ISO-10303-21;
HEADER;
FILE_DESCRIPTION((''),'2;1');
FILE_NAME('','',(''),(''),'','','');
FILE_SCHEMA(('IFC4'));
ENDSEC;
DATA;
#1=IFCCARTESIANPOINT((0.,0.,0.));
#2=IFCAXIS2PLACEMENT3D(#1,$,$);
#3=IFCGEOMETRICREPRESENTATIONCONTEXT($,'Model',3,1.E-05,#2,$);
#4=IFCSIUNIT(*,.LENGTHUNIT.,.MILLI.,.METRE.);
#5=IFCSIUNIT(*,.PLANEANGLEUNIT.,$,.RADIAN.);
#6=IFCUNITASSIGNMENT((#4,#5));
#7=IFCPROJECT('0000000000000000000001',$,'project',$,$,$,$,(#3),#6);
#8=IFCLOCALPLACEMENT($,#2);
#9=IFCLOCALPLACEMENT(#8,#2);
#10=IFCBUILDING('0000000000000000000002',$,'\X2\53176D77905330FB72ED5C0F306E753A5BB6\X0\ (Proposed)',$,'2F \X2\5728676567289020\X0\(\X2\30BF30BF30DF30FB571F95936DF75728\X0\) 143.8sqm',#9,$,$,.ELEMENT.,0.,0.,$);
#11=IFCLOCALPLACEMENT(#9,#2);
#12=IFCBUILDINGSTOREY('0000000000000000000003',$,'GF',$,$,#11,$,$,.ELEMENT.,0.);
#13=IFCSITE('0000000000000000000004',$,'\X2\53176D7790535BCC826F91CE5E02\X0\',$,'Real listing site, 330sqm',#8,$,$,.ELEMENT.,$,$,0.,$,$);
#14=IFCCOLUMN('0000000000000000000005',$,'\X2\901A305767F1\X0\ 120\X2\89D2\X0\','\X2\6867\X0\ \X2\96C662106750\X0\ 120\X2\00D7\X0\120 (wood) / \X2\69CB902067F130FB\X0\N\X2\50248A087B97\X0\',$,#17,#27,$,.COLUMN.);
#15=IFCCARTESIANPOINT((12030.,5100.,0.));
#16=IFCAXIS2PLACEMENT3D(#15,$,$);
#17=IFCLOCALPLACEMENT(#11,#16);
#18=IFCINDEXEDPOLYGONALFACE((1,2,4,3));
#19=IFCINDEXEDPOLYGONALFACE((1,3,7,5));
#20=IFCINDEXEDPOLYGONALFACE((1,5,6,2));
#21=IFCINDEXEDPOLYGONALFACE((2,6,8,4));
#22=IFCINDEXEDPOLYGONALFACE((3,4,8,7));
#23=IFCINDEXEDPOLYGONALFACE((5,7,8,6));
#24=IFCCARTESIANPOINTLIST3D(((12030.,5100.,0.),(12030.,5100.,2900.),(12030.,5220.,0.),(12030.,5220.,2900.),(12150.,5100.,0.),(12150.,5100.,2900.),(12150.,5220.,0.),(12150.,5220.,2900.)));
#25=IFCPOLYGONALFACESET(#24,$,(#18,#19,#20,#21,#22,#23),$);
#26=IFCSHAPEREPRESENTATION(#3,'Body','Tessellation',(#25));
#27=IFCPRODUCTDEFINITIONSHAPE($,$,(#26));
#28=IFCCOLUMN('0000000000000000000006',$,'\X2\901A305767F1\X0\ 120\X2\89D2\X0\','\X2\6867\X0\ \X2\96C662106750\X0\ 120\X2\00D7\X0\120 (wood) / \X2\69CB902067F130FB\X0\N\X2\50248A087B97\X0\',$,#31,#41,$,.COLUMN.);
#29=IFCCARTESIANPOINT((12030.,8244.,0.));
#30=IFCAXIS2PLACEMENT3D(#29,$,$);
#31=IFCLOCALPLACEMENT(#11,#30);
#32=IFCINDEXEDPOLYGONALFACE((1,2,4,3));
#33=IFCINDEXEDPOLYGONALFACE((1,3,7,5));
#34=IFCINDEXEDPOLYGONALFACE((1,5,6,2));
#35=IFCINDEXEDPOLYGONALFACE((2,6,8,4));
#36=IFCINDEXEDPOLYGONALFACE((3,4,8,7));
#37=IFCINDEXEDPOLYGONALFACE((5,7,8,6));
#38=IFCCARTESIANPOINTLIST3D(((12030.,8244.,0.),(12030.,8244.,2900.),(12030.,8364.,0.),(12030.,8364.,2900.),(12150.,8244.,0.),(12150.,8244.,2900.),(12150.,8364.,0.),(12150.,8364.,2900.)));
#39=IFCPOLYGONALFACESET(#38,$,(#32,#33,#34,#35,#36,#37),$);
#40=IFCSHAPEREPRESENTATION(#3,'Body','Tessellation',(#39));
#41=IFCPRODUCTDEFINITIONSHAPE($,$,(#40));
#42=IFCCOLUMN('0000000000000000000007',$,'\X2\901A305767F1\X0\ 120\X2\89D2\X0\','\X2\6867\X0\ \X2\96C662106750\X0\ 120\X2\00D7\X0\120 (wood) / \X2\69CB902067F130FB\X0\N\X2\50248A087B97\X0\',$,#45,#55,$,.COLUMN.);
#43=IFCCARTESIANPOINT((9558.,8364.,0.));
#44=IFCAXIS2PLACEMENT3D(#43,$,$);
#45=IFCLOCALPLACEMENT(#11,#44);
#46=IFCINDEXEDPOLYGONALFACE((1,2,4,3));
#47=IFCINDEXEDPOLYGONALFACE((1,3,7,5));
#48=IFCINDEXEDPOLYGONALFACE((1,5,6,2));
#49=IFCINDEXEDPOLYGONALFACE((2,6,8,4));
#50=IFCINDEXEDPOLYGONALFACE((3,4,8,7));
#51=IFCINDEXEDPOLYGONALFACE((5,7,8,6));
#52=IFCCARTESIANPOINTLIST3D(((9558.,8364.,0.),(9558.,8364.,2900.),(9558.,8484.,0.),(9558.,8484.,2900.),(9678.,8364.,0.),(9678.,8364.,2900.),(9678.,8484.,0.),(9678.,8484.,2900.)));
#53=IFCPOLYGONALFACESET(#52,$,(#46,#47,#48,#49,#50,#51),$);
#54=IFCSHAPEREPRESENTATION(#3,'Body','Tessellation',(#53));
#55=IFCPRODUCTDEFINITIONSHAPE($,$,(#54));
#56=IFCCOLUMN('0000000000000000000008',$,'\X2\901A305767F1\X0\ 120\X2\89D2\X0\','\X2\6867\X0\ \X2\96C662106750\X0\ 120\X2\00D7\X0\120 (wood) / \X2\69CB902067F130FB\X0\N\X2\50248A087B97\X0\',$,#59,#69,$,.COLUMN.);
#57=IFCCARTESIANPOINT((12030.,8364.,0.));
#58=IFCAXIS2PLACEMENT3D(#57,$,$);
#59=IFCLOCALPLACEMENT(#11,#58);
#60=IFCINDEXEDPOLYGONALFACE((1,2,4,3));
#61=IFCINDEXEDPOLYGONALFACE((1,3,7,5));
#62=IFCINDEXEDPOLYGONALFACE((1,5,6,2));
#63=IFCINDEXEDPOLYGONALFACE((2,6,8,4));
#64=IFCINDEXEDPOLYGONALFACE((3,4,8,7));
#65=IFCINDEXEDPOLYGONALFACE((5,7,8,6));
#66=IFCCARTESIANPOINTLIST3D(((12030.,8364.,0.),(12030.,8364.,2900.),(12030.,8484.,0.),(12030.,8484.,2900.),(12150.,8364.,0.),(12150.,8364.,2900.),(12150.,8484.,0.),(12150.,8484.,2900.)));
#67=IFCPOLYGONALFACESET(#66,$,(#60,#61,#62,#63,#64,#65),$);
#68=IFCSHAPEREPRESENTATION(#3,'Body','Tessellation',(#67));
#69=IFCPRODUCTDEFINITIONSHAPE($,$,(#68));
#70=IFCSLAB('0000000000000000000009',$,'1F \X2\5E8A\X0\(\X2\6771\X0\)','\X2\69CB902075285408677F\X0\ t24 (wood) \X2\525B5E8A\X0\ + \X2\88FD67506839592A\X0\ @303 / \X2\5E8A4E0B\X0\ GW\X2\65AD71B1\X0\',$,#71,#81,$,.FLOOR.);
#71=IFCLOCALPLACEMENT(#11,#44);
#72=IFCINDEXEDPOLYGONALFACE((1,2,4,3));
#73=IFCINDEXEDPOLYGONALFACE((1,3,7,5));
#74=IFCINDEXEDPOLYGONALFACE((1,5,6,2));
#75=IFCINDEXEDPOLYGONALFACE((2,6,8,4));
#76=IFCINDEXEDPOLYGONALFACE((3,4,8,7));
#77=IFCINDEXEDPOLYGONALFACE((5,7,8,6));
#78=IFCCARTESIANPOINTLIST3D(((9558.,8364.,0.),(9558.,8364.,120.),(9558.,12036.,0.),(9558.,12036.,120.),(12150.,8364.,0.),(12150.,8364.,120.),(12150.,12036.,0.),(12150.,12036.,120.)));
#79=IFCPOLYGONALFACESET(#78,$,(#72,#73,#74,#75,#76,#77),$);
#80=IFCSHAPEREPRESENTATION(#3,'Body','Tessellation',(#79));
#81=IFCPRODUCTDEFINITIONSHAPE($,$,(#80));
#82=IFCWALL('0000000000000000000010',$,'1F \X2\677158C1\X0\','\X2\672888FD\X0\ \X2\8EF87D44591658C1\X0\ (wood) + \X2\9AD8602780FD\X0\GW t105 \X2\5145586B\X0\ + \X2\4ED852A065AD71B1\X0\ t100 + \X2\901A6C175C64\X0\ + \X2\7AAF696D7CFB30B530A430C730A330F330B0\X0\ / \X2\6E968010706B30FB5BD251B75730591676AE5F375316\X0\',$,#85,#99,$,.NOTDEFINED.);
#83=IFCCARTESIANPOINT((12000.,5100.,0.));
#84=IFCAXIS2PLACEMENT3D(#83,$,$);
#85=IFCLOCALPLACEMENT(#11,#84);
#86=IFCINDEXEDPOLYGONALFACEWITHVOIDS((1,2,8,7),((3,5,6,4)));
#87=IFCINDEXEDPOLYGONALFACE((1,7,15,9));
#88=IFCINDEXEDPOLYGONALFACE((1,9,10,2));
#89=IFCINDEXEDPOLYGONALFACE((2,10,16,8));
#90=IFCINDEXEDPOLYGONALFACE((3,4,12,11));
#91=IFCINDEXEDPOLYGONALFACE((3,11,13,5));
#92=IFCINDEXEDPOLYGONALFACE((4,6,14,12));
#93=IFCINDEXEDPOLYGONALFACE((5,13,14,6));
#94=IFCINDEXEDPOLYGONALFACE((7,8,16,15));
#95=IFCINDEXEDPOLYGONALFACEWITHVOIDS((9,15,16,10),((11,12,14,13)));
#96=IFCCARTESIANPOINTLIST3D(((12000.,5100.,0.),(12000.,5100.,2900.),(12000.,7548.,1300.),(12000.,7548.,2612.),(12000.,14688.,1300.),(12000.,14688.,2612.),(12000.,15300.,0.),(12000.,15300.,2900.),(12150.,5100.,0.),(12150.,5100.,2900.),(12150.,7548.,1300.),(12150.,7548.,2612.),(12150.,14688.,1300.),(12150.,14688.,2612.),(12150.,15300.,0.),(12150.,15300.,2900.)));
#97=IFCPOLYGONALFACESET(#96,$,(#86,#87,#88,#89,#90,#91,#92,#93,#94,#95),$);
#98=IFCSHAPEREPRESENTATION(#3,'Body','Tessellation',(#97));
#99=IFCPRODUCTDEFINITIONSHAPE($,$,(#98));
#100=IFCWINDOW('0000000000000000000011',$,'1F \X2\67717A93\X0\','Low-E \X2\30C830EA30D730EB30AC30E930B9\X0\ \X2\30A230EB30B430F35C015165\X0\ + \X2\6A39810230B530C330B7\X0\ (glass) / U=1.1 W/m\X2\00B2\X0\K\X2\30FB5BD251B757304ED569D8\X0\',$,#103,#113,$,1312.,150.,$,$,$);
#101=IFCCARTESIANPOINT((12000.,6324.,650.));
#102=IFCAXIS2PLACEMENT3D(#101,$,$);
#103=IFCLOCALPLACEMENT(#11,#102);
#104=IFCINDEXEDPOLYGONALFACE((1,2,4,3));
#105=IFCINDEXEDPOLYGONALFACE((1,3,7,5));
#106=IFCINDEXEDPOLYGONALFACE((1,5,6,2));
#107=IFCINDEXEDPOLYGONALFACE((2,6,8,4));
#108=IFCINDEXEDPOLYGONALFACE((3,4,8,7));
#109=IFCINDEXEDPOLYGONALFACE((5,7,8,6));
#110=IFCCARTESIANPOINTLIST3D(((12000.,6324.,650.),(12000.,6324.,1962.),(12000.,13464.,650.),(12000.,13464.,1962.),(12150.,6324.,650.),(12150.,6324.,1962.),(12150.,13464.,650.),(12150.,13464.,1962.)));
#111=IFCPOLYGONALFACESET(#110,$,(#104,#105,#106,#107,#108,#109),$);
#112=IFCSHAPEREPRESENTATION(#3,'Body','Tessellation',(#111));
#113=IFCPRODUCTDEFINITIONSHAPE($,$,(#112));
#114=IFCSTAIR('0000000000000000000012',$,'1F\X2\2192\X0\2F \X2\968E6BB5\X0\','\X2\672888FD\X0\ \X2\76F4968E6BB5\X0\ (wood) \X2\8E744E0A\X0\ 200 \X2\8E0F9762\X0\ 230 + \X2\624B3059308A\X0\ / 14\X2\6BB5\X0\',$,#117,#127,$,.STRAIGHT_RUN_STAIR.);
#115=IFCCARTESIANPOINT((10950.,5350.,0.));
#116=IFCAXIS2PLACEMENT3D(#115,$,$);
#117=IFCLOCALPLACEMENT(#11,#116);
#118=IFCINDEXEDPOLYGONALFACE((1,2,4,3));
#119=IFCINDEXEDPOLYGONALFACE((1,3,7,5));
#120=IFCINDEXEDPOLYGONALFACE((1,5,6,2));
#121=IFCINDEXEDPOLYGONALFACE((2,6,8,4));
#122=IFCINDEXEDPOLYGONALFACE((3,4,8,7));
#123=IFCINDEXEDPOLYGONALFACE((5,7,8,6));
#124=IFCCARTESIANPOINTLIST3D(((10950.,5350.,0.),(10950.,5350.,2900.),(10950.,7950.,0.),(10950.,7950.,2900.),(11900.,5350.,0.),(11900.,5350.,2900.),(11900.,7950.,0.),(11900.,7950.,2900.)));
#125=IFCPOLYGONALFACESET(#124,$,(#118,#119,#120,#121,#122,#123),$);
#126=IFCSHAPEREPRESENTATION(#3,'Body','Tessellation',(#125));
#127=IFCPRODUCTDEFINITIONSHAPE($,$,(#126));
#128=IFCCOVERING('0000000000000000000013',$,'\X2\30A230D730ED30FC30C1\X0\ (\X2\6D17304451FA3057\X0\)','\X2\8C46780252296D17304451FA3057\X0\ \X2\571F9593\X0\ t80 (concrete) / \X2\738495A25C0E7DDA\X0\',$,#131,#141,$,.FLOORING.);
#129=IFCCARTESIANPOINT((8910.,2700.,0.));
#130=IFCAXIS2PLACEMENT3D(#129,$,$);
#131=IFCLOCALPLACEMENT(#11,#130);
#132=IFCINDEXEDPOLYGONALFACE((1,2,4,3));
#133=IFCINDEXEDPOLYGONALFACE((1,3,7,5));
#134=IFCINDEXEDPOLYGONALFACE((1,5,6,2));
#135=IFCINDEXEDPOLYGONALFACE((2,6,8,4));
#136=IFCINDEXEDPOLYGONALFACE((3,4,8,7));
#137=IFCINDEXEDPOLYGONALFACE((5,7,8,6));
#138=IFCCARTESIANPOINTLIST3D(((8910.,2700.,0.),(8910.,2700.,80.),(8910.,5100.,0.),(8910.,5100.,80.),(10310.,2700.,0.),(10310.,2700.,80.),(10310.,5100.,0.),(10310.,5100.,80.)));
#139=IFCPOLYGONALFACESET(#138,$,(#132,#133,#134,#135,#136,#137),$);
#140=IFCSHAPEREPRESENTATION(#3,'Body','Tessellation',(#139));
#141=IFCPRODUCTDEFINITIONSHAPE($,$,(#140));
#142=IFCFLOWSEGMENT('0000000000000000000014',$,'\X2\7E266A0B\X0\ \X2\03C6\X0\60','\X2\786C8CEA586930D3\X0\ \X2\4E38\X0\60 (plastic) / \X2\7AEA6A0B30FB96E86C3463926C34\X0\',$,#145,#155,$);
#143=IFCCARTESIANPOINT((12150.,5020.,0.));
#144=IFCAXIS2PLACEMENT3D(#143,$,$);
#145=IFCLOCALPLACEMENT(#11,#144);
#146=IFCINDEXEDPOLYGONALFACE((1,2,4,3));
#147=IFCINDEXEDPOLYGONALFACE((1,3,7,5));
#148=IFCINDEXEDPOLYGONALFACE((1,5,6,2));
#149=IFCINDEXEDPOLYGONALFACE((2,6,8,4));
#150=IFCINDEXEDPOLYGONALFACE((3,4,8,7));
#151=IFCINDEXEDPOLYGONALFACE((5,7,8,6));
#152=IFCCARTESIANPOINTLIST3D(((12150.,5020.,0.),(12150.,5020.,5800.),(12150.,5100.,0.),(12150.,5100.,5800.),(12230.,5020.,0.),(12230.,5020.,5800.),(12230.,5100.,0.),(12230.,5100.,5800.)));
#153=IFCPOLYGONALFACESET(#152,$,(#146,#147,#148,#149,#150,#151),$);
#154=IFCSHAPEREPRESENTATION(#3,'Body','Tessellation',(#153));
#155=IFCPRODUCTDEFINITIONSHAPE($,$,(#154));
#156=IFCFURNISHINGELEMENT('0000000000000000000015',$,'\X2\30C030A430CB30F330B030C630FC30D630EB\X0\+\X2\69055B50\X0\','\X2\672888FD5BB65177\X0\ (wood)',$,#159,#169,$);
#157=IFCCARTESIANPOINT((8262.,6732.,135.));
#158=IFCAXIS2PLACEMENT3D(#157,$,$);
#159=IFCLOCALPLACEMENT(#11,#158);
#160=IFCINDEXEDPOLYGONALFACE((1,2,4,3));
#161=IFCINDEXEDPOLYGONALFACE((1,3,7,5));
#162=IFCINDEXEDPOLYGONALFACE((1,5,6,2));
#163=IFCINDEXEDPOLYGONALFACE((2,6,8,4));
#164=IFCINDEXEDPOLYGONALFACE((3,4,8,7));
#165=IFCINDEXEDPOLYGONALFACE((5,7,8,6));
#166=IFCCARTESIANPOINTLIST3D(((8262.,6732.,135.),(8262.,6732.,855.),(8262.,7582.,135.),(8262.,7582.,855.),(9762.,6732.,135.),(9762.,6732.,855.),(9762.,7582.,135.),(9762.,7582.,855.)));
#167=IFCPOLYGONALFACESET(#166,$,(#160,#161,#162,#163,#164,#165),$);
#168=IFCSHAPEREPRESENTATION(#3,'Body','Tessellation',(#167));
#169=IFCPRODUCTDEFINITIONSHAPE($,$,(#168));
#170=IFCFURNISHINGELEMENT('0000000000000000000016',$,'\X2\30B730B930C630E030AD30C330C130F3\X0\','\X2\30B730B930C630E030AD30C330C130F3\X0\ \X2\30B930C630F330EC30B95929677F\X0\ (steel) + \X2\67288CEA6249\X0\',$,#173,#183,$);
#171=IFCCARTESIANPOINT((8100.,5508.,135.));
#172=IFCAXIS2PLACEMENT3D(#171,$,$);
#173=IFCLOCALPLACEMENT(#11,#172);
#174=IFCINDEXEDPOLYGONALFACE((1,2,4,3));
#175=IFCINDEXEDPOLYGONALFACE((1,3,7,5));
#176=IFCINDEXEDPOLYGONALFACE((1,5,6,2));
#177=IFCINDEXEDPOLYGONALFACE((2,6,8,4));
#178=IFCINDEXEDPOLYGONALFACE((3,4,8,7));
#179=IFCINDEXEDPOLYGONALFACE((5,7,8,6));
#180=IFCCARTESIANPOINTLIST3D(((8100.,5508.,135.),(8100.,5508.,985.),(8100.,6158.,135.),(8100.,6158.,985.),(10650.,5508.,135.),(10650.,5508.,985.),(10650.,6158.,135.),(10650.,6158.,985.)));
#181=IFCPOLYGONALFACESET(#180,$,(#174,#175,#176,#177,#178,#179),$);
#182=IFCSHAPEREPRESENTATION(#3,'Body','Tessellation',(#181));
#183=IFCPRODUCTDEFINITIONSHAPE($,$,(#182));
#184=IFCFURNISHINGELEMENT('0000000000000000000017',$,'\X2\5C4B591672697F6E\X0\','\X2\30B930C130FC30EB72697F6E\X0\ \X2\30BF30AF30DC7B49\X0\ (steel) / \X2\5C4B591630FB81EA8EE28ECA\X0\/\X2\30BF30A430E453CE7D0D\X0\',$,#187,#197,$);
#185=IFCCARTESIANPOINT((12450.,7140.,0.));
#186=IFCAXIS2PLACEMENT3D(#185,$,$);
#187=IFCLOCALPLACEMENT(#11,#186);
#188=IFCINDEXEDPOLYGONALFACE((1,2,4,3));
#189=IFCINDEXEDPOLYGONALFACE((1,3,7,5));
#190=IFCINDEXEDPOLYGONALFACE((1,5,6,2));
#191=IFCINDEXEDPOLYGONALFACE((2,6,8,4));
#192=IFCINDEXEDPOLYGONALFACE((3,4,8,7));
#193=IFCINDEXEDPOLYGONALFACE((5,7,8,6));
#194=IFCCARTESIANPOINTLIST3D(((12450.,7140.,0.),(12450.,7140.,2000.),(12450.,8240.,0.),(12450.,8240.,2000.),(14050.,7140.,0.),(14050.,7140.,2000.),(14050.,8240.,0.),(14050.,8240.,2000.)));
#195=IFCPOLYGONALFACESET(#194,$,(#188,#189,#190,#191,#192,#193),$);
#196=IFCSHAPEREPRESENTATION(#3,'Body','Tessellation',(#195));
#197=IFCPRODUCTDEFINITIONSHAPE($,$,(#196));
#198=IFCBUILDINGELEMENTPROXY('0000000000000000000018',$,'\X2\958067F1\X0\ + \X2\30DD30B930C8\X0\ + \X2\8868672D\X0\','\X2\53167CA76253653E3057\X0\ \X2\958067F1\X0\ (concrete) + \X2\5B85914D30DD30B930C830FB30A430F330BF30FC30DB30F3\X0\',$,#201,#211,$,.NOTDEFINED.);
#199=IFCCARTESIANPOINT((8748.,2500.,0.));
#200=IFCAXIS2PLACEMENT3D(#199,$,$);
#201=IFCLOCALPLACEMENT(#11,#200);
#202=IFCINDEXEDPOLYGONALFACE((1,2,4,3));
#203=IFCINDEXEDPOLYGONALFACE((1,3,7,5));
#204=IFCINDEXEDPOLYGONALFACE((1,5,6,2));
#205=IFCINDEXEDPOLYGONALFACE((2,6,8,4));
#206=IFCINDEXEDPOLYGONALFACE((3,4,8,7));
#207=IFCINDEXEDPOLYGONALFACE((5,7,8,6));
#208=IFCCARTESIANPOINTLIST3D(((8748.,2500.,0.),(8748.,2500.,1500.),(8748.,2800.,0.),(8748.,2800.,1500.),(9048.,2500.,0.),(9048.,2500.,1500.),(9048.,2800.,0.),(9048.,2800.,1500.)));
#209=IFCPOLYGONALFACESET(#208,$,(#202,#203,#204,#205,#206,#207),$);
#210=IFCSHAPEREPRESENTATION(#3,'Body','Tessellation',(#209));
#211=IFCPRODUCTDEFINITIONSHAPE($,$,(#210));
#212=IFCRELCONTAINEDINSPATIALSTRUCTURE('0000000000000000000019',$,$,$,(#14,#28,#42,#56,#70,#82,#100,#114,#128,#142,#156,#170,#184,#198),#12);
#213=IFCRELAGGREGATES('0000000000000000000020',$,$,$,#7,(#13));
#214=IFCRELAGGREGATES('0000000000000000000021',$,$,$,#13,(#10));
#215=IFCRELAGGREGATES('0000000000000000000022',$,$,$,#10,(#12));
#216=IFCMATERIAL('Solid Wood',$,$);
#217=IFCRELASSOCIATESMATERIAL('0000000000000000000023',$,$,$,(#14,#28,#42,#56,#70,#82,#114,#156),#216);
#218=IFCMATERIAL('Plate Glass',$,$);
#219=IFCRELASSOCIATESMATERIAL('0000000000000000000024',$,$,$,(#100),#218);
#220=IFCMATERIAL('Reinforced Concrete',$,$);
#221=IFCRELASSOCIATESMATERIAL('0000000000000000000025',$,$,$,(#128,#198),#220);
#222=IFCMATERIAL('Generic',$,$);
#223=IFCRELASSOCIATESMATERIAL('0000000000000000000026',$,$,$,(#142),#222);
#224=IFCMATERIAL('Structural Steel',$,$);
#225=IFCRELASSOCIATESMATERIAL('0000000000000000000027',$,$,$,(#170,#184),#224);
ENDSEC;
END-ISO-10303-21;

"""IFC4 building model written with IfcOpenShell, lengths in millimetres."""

from ifc_helpers import new_model, si_unit, frame, frame_2d, origin, place, context, project, spatial, rectangle, extrude, material, element, fill, save


model = new_model("IFC4")

# Units and contexts
model_context = context("Model", 3, precision=1e-05, world=origin())
ifc_project = project(units=[si_unit("LENGTHUNIT", "METRE", prefix="MILLI"), si_unit("PLANEANGLEUNIT", "RADIAN")], contexts=[model_context])

# Site, building, storey
site_placement = place(None, origin())
site = spatial("IfcSite", under=ifc_project, at=site_placement, Name="北海道富良野市", ObjectType="Real listing site, 330sqm", CompositionType="ELEMENT", RefElevation=0.0)
building_placement = place(site_placement, origin())
building = spatial("IfcBuilding", under=site, at=building_placement, Name="北海道・狭小の町家 (Proposed)", ObjectType="2F 在来木造(タタミ・土間混在) 143.8sqm", CompositionType="ELEMENT", ElevationOfRefHeight=0.0, ElevationOfTerrain=0.0)
storey_placement = place(building_placement, origin())
storey = spatial("IfcBuildingStorey", under=building, at=storey_placement, Name="GF", CompositionType="ELEMENT", Elevation=0.0)

# Columns
ifc_material_1 = material(Name="Solid Wood")
column_1_placement = place(storey_placement, frame((12030.0, 5100.0, 0.0)))
element("IfcColumn", 1, at=column_1_placement, inside=storey, material=ifc_material_1, Name="通し柱 120角", Description="桧 集成材 120×120 (wood) / 構造柱・N値計算", PredefinedType="COLUMN", context=model_context, shape_type="SweptSolid", body=[
    extrude(rectangle(XDim=120.0, YDim=120.0, at=frame_2d((60.0, 60.0))), frame((12030.0, 5100.0, 0.0)), (0.0, 0.0, 1.0), 2900.0),
])
column_2_placement = place(storey_placement, frame((12030.0, 8244.0, 0.0)))
element("IfcColumn", 2, at=column_2_placement, inside=storey, material=ifc_material_1, Name="通し柱 120角", Description="桧 集成材 120×120 (wood) / 構造柱・N値計算", PredefinedType="COLUMN", context=model_context, shape_type="SweptSolid", body=[
    extrude(rectangle(XDim=120.0, YDim=120.0, at=frame_2d((60.0, 60.0))), frame((12030.0, 8244.0, 0.0)), (0.0, 0.0, 1.0), 2900.0),
])
column_3_placement = place(storey_placement, frame((9558.0, 8364.0, 0.0)))
element("IfcColumn", 3, at=column_3_placement, inside=storey, material=ifc_material_1, Name="通し柱 120角", Description="桧 集成材 120×120 (wood) / 構造柱・N値計算", PredefinedType="COLUMN", context=model_context, shape_type="SweptSolid", body=[
    extrude(rectangle(XDim=120.0, YDim=120.0, at=frame_2d((60.0, 60.0))), frame((9558.0, 8364.0, 0.0)), (0.0, 0.0, 1.0), 2900.0),
])
column_4_placement = place(storey_placement, frame((12030.0, 8364.0, 0.0)))
element("IfcColumn", 4, at=column_4_placement, inside=storey, material=ifc_material_1, Name="通し柱 120角", Description="桧 集成材 120×120 (wood) / 構造柱・N値計算", PredefinedType="COLUMN", context=model_context, shape_type="SweptSolid", body=[
    extrude(rectangle(XDim=120.0, YDim=120.0, at=frame_2d((60.0, 60.0))), frame((12030.0, 8364.0, 0.0)), (0.0, 0.0, 1.0), 2900.0),
])

# Slab
slab_placement = place(storey_placement, frame((9558.0, 8364.0, 0.0)))
element("IfcSlab", 5, at=slab_placement, inside=storey, material=ifc_material_1, Name="1F 床(東)", Description="構造用合板 t24 (wood) 剛床 + 製材根太 @303 / 床下 GW断熱", PredefinedType="FLOOR", context=model_context, shape_type="SweptSolid", body=[
    extrude(rectangle(XDim=2592.0, YDim=3672.0, at=frame_2d((1296.0, 1836.0))), frame((9558.0, 8364.0, 0.0)), (0.0, 0.0, 1.0), 120.0),
])

# Wall, opening, window
wall_1_placement = place(storey_placement, frame((12000.0, 5100.0, 0.0)))
wall_1 = element("IfcWall", 6, at=wall_1_placement, inside=storey, material=ifc_material_1, Name="1F 東壁", Description="木製 軸組外壁 (wood) + 高性能GW t105 充填 + 付加断熱 t100 + 通気層 + 窯業系サイディング / 準耐火・寒冷地外皮強化", PredefinedType="NOTDEFINED", context=model_context, shape_type="SweptSolid", body=[
    extrude(rectangle(XDim=150.0, YDim=10200.0, at=frame_2d((75.0, 5100.0))), frame((12000.0, 5100.0, 0.0)), (0.0, 0.0, 1.0), 2900.0),
])
opening_placement = place(storey_placement, frame((12000.0, 6324.0, 650.0)))
opening = element("IfcOpeningElement", 7, at=opening_placement, cuts=wall_1, PredefinedType="NOTDEFINED", context=model_context, shape_type="SweptSolid", body=[
    extrude(rectangle(XDim=150.0, YDim=7140.0, at=frame_2d((75.0, 3570.0))), frame((12000.0, 6324.0, 650.0)), (0.0, 0.0, 1.0), 1312.0),
])
ifc_material_2 = material(Name="Plate Glass")
window_placement = place(storey_placement, frame((12000.0, 6324.0, 650.0)))
window = element("IfcWindow", 8, at=window_placement, inside=storey, material=ifc_material_2, Name="1F 東窓", Description="Low-E トリプルガラス アルゴン封入 + 樹脂サッシ (glass) / U=1.1 W/m²K・寒冷地仕様", OverallHeight=1312.0, OverallWidth=150.0, context=model_context, shape_type="SweptSolid", body=[
    extrude(rectangle(XDim=150.0, YDim=7140.0, at=frame_2d((75.0, 3570.0))), frame((12000.0, 6324.0, 650.0)), (0.0, 0.0, 1.0), 1312.0),
])
fill(opening, window)

# Stair
stair_placement = place(storey_placement, frame((10950.0, 5350.0, 0.0)))
element("IfcStair", 9, at=stair_placement, inside=storey, material=ifc_material_1, Name="1F→2F 階段", Description="木製 直階段 (wood) 蹴上 200 踏面 230 + 手すり / 14段", PredefinedType="STRAIGHT_RUN_STAIR", context=model_context, shape_type="SweptSolid", body=[
    extrude(rectangle(XDim=950.0, YDim=2600.0, at=frame_2d((475.0, 1300.0))), frame((10950.0, 5350.0, 0.0)), (0.0, 0.0, 1.0), 2900.0),
])

# Covering
ifc_material_3 = material(Name="Reinforced Concrete")
covering_placement = place(storey_placement, frame((8910.0, 2700.0, 0.0)))
element("IfcCovering", 10, at=covering_placement, inside=storey, material=ifc_material_3, Name="アプローチ (洗い出し)", Description="豆砂利洗い出し 土間 t80 (concrete) / 玄関導線", PredefinedType="FLOORING", context=model_context, shape_type="SweptSolid", body=[
    extrude(rectangle(XDim=1400.0, YDim=2400.0, at=frame_2d((700.0, 1200.0))), frame((8910.0, 2700.0, 0.0)), (0.0, 0.0, 1.0), 80.0),
])

# Flow segment
ifc_material_4 = material(Name="Generic")
flow_segment_placement = place(storey_placement, frame((12150.0, 5020.0, 0.0)))
element("IfcFlowSegment", 11, at=flow_segment_placement, inside=storey, material=ifc_material_4, Name="縦樋 φ60", Description="硬質塩ビ 丸60 (plastic) / 竪樋・雨水排水", context=model_context, shape_type="SweptSolid", body=[
    extrude(rectangle(XDim=80.0, YDim=80.0, at=frame_2d((40.0, 40.0))), frame((12150.0, 5020.0, 0.0)), (0.0, 0.0, 1.0), 5800.0),
])

# Furnishing elements
furnishing_1_placement = place(storey_placement, frame((8262.0, 6732.0, 135.0)))
element("IfcFurnishingElement", 12, at=furnishing_1_placement, inside=storey, material=ifc_material_1, Name="ダイニングテーブル+椅子", Description="木製家具 (wood)", context=model_context, shape_type="SweptSolid", body=[
    extrude(rectangle(XDim=1500.0, YDim=850.0, at=frame_2d((750.0, 425.0))), frame((8262.0, 6732.0, 135.0)), (0.0, 0.0, 1.0), 720.0),
])
ifc_material_5 = material(Name="Structural Steel")
furnishing_2_placement = place(storey_placement, frame((8100.0, 5508.0, 135.0)))
element("IfcFurnishingElement", 13, at=furnishing_2_placement, inside=storey, material=ifc_material_5, Name="システムキッチン", Description="システムキッチン ステンレス天板 (steel) + 木質扉", context=model_context, shape_type="SweptSolid", body=[
    extrude(rectangle(XDim=2550.0, YDim=650.0, at=frame_2d((1275.0, 325.0))), frame((8100.0, 5508.0, 135.0)), (0.0, 0.0, 1.0), 850.0),
])
furnishing_3_placement = place(storey_placement, frame((12450.0, 7140.0, 0.0)))
element("IfcFurnishingElement", 14, at=furnishing_3_placement, inside=storey, material=ifc_material_5, Name="屋外物置", Description="スチール物置 タクボ等 (steel) / 屋外・自転車/タイヤ収納", context=model_context, shape_type="SweptSolid", body=[
    extrude(rectangle(XDim=1600.0, YDim=1100.0, at=frame_2d((800.0, 550.0))), frame((12450.0, 7140.0, 0.0)), (0.0, 0.0, 1.0), 2000.0),
])

# Building element proxy
proxy_placement = place(storey_placement, frame((8748.0, 2500.0, 0.0)))
element("IfcBuildingElementProxy", 15, at=proxy_placement, inside=storey, material=ifc_material_3, Name="門柱 + ポスト + 表札", Description="化粧打放し 門柱 (concrete) + 宅配ポスト・インターホン", PredefinedType="NOTDEFINED", context=model_context, shape_type="SweptSolid", body=[
    extrude(rectangle(XDim=300.0, YDim=300.0, at=frame_2d((150.0, 150.0))), frame((8748.0, 2500.0, 0.0)), (0.0, 0.0, 1.0), 1500.0),
])

save(model, "model.ifc")
